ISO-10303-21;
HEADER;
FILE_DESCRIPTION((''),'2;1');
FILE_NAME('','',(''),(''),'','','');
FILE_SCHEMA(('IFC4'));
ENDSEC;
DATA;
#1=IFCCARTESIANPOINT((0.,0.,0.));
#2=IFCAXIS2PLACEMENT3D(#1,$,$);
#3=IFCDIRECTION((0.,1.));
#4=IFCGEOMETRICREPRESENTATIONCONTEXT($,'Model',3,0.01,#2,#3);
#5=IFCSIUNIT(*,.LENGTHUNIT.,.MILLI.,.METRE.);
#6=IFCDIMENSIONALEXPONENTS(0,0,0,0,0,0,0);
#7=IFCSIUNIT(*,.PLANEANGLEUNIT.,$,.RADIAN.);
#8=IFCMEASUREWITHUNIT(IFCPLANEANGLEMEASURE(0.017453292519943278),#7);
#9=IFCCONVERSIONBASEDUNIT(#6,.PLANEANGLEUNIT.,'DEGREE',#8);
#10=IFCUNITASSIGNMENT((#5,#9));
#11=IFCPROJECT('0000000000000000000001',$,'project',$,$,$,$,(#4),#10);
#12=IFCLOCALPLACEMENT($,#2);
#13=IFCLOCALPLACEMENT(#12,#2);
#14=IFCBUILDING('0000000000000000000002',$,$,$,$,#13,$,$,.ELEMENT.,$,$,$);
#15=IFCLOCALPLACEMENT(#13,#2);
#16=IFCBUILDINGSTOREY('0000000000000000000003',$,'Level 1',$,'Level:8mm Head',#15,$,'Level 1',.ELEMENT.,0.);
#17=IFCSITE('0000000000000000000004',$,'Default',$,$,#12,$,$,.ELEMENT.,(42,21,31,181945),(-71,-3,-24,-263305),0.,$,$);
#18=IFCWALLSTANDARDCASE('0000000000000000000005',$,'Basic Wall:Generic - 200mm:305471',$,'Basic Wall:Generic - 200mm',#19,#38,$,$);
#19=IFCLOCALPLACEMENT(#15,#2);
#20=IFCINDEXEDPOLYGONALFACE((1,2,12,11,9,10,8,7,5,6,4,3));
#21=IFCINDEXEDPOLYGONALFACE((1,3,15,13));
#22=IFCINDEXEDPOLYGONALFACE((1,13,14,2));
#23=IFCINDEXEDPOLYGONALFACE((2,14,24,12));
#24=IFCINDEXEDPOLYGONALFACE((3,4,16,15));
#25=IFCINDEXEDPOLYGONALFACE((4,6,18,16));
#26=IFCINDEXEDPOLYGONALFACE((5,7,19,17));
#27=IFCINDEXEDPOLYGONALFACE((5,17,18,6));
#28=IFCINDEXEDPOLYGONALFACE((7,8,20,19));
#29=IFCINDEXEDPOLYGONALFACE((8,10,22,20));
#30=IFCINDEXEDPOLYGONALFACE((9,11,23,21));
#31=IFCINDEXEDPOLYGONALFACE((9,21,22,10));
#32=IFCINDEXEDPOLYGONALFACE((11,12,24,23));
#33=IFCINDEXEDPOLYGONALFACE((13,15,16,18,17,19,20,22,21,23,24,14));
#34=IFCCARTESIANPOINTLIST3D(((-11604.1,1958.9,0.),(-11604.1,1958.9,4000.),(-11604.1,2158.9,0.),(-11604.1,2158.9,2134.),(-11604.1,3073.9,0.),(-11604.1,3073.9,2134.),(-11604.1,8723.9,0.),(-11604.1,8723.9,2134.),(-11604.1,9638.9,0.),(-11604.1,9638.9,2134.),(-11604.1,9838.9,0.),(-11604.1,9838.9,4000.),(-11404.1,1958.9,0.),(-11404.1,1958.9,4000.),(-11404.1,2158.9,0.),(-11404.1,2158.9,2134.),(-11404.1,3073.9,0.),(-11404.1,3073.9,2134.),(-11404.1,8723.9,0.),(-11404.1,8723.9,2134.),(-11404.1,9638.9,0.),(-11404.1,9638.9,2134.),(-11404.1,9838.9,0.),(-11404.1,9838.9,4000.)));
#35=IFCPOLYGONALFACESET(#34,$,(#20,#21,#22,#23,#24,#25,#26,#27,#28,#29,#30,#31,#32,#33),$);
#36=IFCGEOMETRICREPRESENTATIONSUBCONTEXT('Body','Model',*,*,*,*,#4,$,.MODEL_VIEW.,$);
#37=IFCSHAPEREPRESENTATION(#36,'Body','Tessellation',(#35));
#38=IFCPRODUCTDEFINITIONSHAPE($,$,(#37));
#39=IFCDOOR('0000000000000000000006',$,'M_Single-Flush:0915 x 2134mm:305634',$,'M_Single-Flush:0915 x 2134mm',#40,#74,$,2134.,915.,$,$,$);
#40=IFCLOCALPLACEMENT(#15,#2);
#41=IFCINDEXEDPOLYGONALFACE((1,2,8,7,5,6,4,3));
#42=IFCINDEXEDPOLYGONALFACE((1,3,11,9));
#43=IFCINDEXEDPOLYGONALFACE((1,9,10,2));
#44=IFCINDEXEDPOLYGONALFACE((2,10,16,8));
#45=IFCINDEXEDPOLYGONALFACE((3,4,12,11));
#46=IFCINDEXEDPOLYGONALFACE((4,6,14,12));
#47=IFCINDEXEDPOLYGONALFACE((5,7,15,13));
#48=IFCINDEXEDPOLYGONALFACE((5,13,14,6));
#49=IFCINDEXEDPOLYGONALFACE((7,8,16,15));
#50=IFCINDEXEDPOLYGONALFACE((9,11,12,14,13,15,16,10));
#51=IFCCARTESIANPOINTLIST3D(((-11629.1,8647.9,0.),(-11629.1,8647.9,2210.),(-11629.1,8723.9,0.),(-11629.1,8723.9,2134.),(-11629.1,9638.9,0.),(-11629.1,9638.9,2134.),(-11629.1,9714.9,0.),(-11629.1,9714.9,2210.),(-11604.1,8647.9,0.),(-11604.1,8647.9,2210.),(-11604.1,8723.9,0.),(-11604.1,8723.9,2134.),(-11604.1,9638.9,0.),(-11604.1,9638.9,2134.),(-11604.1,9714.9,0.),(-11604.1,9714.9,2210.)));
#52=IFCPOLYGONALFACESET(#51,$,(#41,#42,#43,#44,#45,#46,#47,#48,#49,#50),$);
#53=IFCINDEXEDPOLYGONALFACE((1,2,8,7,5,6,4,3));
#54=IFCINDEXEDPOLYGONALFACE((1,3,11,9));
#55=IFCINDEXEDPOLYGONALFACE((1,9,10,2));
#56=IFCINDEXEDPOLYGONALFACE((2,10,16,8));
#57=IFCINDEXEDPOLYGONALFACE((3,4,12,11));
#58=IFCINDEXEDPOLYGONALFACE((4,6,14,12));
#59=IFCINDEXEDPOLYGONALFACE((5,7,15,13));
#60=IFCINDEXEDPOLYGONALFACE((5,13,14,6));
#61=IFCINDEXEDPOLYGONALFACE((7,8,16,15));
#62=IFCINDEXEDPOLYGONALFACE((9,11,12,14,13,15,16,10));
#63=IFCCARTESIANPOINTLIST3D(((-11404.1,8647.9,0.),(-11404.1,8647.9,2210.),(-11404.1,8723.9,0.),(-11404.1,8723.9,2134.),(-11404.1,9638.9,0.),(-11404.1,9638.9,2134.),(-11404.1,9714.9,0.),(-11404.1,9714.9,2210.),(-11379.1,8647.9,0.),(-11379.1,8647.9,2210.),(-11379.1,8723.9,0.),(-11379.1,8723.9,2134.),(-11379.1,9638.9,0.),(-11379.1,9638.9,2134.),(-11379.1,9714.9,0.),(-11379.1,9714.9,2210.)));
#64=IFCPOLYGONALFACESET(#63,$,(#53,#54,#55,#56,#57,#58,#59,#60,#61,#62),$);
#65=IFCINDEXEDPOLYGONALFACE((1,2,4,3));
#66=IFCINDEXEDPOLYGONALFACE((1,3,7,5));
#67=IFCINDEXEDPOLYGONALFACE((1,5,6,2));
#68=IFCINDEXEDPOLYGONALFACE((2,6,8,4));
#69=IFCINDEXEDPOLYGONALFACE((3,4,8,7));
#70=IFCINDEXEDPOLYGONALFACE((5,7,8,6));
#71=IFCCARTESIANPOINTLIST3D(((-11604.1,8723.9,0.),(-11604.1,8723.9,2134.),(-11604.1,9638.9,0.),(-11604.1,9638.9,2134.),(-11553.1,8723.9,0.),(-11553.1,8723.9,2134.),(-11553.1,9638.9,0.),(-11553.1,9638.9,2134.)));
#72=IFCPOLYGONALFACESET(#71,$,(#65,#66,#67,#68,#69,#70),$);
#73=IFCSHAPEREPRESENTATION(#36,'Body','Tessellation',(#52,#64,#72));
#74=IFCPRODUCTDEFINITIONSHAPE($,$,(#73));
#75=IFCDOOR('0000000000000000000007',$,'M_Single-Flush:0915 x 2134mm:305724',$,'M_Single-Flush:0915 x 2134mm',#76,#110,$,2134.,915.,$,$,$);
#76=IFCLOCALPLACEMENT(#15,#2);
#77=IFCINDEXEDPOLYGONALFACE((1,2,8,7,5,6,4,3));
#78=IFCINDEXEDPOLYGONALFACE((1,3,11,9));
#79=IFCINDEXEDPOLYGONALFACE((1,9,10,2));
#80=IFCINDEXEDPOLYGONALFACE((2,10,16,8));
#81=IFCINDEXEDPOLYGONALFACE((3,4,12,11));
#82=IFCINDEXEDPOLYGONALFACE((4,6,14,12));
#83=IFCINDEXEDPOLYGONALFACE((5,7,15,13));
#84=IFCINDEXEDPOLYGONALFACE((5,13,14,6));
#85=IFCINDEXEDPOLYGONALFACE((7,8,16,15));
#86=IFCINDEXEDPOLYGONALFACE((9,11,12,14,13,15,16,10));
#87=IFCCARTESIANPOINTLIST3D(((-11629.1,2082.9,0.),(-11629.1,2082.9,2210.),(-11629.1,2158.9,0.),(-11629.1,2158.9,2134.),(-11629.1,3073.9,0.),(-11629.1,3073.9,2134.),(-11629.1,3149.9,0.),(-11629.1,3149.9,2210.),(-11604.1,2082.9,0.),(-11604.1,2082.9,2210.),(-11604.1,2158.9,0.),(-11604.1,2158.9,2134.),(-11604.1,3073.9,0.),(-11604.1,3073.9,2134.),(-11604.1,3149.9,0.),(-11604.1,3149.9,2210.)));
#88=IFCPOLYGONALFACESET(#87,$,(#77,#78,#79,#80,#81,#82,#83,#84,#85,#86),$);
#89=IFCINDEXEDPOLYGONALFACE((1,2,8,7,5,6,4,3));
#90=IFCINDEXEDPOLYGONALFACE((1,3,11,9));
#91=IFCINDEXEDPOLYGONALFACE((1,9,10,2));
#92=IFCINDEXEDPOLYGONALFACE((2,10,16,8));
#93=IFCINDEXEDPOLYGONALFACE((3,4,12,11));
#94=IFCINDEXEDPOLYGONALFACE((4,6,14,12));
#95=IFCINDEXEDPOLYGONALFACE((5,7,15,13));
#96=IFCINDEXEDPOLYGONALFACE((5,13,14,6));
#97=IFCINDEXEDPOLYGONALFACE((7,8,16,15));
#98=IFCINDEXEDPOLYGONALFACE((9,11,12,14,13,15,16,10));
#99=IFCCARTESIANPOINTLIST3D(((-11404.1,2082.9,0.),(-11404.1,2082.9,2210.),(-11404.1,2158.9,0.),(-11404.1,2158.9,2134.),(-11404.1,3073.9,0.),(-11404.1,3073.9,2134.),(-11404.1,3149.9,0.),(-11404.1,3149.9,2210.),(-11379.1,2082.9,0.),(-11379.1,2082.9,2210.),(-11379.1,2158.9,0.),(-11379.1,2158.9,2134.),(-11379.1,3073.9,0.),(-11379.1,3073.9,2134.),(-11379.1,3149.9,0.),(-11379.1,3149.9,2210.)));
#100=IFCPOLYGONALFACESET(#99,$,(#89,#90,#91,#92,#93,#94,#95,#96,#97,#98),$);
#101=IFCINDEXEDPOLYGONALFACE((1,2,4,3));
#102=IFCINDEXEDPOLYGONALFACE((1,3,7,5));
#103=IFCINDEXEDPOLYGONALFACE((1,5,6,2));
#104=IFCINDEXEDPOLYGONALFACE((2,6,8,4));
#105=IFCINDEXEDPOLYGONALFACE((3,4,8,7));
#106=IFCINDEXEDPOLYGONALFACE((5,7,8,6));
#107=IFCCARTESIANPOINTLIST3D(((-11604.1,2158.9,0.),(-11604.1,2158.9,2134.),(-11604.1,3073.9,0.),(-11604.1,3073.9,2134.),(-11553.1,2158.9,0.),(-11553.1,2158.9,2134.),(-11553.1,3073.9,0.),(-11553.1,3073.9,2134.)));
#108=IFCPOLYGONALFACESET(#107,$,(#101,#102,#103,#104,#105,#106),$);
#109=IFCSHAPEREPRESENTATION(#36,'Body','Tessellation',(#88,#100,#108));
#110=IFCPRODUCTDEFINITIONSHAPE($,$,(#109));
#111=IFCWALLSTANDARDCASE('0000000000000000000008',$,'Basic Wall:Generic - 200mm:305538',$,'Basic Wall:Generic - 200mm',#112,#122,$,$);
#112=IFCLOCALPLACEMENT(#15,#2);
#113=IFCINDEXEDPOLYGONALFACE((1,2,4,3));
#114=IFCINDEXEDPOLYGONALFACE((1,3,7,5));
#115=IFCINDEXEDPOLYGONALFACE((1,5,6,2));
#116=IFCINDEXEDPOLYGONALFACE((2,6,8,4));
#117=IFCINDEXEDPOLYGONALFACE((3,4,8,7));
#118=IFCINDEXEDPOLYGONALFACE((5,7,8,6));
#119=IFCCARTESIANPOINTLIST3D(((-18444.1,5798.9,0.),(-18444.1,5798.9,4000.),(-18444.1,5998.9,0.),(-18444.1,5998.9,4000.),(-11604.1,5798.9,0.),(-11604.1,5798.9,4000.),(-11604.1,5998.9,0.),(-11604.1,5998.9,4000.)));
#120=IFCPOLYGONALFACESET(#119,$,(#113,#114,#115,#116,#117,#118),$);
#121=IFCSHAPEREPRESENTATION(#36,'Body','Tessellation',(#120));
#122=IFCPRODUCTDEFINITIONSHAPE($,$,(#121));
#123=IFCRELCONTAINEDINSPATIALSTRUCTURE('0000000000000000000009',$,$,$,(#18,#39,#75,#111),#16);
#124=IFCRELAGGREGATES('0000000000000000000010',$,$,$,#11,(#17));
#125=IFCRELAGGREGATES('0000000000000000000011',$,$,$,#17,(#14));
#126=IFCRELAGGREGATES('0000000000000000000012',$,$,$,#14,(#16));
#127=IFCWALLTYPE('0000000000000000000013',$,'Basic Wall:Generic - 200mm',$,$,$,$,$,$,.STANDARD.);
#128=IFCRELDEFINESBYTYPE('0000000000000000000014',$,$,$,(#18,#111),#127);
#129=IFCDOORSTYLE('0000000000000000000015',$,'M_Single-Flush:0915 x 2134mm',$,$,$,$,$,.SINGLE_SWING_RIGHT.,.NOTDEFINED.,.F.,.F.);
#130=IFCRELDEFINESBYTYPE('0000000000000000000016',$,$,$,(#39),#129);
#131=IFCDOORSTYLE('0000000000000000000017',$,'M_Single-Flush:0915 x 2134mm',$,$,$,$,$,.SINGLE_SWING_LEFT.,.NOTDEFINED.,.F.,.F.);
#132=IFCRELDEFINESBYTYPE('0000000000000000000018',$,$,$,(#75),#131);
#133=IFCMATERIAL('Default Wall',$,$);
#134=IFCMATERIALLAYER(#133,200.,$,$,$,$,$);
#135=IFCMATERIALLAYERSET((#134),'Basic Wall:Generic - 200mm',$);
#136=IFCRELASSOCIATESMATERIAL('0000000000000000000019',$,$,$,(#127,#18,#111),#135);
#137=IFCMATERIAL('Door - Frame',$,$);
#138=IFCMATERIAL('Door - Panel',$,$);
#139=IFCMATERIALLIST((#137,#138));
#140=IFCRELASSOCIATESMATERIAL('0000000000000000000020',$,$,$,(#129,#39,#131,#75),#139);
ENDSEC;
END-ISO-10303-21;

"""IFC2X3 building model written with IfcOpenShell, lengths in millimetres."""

from ifc_helpers import new_model, entity, si_unit, converted_unit, direction, frame, frame_2d, origin, place, context, subcontext, project, spatial, polyline, rectangle, outline, extrude, source, transform, mapped, material, material_list, layer, layer_set, layer_usage, type_object, type_shapes, element, fill, save


model = new_model("IFC2X3")

# Units and contexts
model_context = context("Model", 3, precision=0.01, world=origin(), true_north=direction((0.0, 1.0)))
body_context = subcontext(model_context, "Body", "Model", "MODEL_VIEW")
ifc_project = project(units=[si_unit("LENGTHUNIT", "METRE", prefix="MILLI"), converted_unit("PLANEANGLEUNIT", "DEGREE", entity("IfcPlaneAngleMeasure", 0.017453292519943278), si_unit("PLANEANGLEUNIT", "RADIAN"), dimensions=[0, 0, 0, 0, 0, 0, 0])], contexts=[model_context])

# Site, building, storey
site_placement = place(None, origin())
site = spatial("IfcSite", under=ifc_project, at=site_placement, Name="Default", CompositionType="ELEMENT", RefLatitude=(42, 21, 31, 181945), RefLongitude=(-71, -3, -24, -263305), RefElevation=0.0)
building_placement = place(site_placement, origin())
building = spatial("IfcBuilding", under=site, at=building_placement, CompositionType="ELEMENT")
storey_placement = place(building_placement, origin())
storey = spatial("IfcBuildingStorey", under=building, at=storey_placement, Name="Level 1", ObjectType="Level:8mm Head", LongName="Level 1", CompositionType="ELEMENT", Elevation=0.0)

# Shared definitions
ifc_material_1 = material(Name="Door - Frame")
ifc_material_2 = material(Name="Door - Panel")
ifc_material_list = material_list([ifc_material_1, ifc_material_2])

# Wall, openings, doors
ifc_material_3 = material(Name="Default Wall")
ifc_layer_1 = layer(ifc_material_3, 200.0)
ifc_layer_set_1 = layer_set([ifc_layer_1], Name="Basic Wall:Generic - 200mm")
ifc_layer_usage_1 = layer_usage(ifc_layer_set_1, "AXIS2", "NEGATIVE", 100.0)
wall_type_1 = type_object("IfcWallType", Name="Basic Wall:Generic - 200mm", PredefinedType="STANDARD", material=ifc_layer_set_1)
wall_1_placement = place(storey_placement, frame((-11504.1, 9838.9, 0.0), z_axis=(0.0, 0.0, 1.0), x_axis=(0.0, -1.0, 0.0)))
wall_1 = element("IfcWallStandardCase", 1, at=wall_1_placement, inside=storey, type_object=wall_type_1, material=ifc_layer_usage_1, Name="Basic Wall:Generic - 200mm:305471", ObjectType="Basic Wall:Generic - 200mm", context=body_context, shape_type="SweptSolid", body=[
    extrude(rectangle(XDim=7880.0, YDim=200.0, at=frame_2d((3940.0, 0.0), x_axis=(1.0, 0.0))), origin(), (0.0, 0.0, 1.0), 4000.0),
])
opening_1_placement = place(wall_1_placement, frame((1115.0, 100.0, 0.0)))
opening_1 = element("IfcOpeningElement", 2, at=opening_1_placement, cuts=wall_1, ObjectType="Opening", context=body_context, shape_type="SweptSolid", body=[
    extrude(rectangle(XDim=915.0, YDim=2134.0, at=frame_2d((1067.0, 457.5), x_axis=(0.0, 1.0))), frame((0.0, 0.0, 0.0), z_axis=(0.0, -1.0, 0.0), x_axis=(0.0, 0.0, 1.0)), (0.0, 0.0, 1.0), 200.0),
])
opening_2_placement = place(wall_1_placement, frame((7680.0, 100.0, 0.0)))
opening_2 = element("IfcOpeningElement", 3, at=opening_2_placement, cuts=wall_1, ObjectType="Opening", context=body_context, shape_type="SweptSolid", body=[
    extrude(rectangle(XDim=915.0, YDim=2134.0, at=frame_2d((1067.0, 457.5), x_axis=(0.0, -1.0))), frame((0.0, 0.0, 0.0), z_axis=(0.0, -1.0, 0.0), x_axis=(0.0, 0.0, 1.0)), (0.0, 0.0, 1.0), 200.0),
])
door_style_1 = type_object("IfcDoorStyle", Name="M_Single-Flush:0915 x 2134mm", ConstructionType="NOTDEFINED", OperationType="SINGLE_SWING_RIGHT", ParameterTakesPrecedence=False, Sizeable=False, material=ifc_material_list)
shared_shape_1 = source(origin(), body_context, "Body", "SweptSolid", [
    extrude(outline(polyline([(-533.5, -1124.0), (533.5, -1124.0), (533.5, 1086.0), (457.5, 1086.0), (457.5, -1048.0), (-457.5, -1048.0), (-457.5, 1086.0), (-533.5, 1086.0), (-533.5, -1124.0)])), frame((457.5, 200.0, 1086.0), z_axis=(0.0, 1.0, 0.0), x_axis=(1.0, 0.0, 0.0)), (0.0, 0.0, 1.0), 25.0),
    extrude(outline(polyline([(-1124.0, -533.5), (1086.0, -533.5), (1086.0, -457.5), (-1048.0, -457.5), (-1048.0, 457.5), (1086.0, 457.5), (1086.0, 533.5), (-1124.0, 533.5), (-1124.0, -533.5)])), frame((457.5, -25.0, 1086.0), z_axis=(0.0, 1.0, 0.0), x_axis=(0.0, 0.0, -1.0)), (0.0, 0.0, 1.0), 25.0),
    extrude(rectangle(XDim=51.0, YDim=915.0, at=frame_2d((0.0, 0.0), x_axis=(1.0, 0.0))), frame((457.5, 174.5, 0.0), z_axis=(0.0, 0.0, 1.0), x_axis=(0.0, 1.0, 0.0)), (0.0, 0.0, 1.0), 2134.0),
])
type_shapes(door_style_1, [shared_shape_1])
door_1_placement = place(opening_1_placement, frame((0.0, 0.0, 0.0), z_axis=(0.0, 0.0, 1.0), x_axis=(-1.0, 0.0, 0.0)))
door_1 = element("IfcDoor", 4, at=door_1_placement, inside=storey, type_object=door_style_1, material=ifc_material_list, Name="M_Single-Flush:0915 x 2134mm:305634", ObjectType="M_Single-Flush:0915 x 2134mm", OverallHeight=2134.0, OverallWidth=915.0, context=body_context, shape_type="MappedRepresentation", body=[
    mapped(shared_shape_1, transform((0.0, 0.0, 0.0), scale=1.0)),
])
fill(opening_1, door_1)
door_style_2 = type_object("IfcDoorStyle", Name="M_Single-Flush:0915 x 2134mm", ConstructionType="NOTDEFINED", OperationType="SINGLE_SWING_LEFT", ParameterTakesPrecedence=False, Sizeable=False, material=ifc_material_list)
shared_shape_2 = source(origin(), body_context, "Body", "SweptSolid", [
    extrude(outline(polyline([(-533.5, -1124.0), (533.5, -1124.0), (533.5, 1086.0), (457.5, 1086.0), (457.5, -1048.0), (-457.5, -1048.0), (-457.5, 1086.0), (-533.5, 1086.0), (-533.5, -1124.0)])), frame((457.5, 225.0, 1086.0), z_axis=(0.0, -1.0, 0.0), x_axis=(-1.0, 0.0, 0.0)), (0.0, 0.0, 1.0), 25.0),
    extrude(outline(polyline([(-1124.0, -533.5), (1086.0, -533.5), (1086.0, -457.5), (-1048.0, -457.5), (-1048.0, 457.5), (1086.0, 457.5), (1086.0, 533.5), (-1124.0, 533.5), (-1124.0, -533.5)])), frame((457.5, 0.0, 1086.0), z_axis=(0.0, -1.0, 0.0), x_axis=(0.0, 0.0, -1.0)), (0.0, 0.0, 1.0), 25.0),
    extrude(rectangle(XDim=915.0, YDim=51.0, at=frame_2d((0.0, 0.0), x_axis=(1.0, 0.0))), frame((457.5, 174.5, 0.0)), (0.0, 0.0, 1.0), 2134.0),
])
type_shapes(door_style_2, [shared_shape_2])
door_2_placement = place(opening_2_placement, frame((0.0, 0.0, 0.0), z_axis=(0.0, 0.0, 1.0), x_axis=(-1.0, 0.0, 0.0)))
door_2 = element("IfcDoor", 5, at=door_2_placement, inside=storey, type_object=door_style_2, material=ifc_material_list, Name="M_Single-Flush:0915 x 2134mm:305724", ObjectType="M_Single-Flush:0915 x 2134mm", OverallHeight=2134.0, OverallWidth=915.0, context=body_context, shape_type="MappedRepresentation", body=[
    mapped(shared_shape_2, transform((0.0, 0.0, 0.0), scale=1.0)),
])
fill(opening_2, door_2)

# Wall
wall_2_placement = place(storey_placement, frame((-11604.1, 5898.9, 0.0), z_axis=(0.0, 0.0, 1.0), x_axis=(-1.0, 0.0, 0.0)))
element("IfcWallStandardCase", 6, at=wall_2_placement, inside=storey, type_object=wall_type_1, material=ifc_layer_usage_1, Name="Basic Wall:Generic - 200mm:305538", ObjectType="Basic Wall:Generic - 200mm", context=body_context, shape_type="SweptSolid", body=[
    extrude(rectangle(XDim=6840.0, YDim=200.0, at=frame_2d((3420.0, 0.0), x_axis=(-1.0, 0.0))), origin(), (0.0, 0.0, 1.0), 4000.0),
])

save(model, "model.ifc")
